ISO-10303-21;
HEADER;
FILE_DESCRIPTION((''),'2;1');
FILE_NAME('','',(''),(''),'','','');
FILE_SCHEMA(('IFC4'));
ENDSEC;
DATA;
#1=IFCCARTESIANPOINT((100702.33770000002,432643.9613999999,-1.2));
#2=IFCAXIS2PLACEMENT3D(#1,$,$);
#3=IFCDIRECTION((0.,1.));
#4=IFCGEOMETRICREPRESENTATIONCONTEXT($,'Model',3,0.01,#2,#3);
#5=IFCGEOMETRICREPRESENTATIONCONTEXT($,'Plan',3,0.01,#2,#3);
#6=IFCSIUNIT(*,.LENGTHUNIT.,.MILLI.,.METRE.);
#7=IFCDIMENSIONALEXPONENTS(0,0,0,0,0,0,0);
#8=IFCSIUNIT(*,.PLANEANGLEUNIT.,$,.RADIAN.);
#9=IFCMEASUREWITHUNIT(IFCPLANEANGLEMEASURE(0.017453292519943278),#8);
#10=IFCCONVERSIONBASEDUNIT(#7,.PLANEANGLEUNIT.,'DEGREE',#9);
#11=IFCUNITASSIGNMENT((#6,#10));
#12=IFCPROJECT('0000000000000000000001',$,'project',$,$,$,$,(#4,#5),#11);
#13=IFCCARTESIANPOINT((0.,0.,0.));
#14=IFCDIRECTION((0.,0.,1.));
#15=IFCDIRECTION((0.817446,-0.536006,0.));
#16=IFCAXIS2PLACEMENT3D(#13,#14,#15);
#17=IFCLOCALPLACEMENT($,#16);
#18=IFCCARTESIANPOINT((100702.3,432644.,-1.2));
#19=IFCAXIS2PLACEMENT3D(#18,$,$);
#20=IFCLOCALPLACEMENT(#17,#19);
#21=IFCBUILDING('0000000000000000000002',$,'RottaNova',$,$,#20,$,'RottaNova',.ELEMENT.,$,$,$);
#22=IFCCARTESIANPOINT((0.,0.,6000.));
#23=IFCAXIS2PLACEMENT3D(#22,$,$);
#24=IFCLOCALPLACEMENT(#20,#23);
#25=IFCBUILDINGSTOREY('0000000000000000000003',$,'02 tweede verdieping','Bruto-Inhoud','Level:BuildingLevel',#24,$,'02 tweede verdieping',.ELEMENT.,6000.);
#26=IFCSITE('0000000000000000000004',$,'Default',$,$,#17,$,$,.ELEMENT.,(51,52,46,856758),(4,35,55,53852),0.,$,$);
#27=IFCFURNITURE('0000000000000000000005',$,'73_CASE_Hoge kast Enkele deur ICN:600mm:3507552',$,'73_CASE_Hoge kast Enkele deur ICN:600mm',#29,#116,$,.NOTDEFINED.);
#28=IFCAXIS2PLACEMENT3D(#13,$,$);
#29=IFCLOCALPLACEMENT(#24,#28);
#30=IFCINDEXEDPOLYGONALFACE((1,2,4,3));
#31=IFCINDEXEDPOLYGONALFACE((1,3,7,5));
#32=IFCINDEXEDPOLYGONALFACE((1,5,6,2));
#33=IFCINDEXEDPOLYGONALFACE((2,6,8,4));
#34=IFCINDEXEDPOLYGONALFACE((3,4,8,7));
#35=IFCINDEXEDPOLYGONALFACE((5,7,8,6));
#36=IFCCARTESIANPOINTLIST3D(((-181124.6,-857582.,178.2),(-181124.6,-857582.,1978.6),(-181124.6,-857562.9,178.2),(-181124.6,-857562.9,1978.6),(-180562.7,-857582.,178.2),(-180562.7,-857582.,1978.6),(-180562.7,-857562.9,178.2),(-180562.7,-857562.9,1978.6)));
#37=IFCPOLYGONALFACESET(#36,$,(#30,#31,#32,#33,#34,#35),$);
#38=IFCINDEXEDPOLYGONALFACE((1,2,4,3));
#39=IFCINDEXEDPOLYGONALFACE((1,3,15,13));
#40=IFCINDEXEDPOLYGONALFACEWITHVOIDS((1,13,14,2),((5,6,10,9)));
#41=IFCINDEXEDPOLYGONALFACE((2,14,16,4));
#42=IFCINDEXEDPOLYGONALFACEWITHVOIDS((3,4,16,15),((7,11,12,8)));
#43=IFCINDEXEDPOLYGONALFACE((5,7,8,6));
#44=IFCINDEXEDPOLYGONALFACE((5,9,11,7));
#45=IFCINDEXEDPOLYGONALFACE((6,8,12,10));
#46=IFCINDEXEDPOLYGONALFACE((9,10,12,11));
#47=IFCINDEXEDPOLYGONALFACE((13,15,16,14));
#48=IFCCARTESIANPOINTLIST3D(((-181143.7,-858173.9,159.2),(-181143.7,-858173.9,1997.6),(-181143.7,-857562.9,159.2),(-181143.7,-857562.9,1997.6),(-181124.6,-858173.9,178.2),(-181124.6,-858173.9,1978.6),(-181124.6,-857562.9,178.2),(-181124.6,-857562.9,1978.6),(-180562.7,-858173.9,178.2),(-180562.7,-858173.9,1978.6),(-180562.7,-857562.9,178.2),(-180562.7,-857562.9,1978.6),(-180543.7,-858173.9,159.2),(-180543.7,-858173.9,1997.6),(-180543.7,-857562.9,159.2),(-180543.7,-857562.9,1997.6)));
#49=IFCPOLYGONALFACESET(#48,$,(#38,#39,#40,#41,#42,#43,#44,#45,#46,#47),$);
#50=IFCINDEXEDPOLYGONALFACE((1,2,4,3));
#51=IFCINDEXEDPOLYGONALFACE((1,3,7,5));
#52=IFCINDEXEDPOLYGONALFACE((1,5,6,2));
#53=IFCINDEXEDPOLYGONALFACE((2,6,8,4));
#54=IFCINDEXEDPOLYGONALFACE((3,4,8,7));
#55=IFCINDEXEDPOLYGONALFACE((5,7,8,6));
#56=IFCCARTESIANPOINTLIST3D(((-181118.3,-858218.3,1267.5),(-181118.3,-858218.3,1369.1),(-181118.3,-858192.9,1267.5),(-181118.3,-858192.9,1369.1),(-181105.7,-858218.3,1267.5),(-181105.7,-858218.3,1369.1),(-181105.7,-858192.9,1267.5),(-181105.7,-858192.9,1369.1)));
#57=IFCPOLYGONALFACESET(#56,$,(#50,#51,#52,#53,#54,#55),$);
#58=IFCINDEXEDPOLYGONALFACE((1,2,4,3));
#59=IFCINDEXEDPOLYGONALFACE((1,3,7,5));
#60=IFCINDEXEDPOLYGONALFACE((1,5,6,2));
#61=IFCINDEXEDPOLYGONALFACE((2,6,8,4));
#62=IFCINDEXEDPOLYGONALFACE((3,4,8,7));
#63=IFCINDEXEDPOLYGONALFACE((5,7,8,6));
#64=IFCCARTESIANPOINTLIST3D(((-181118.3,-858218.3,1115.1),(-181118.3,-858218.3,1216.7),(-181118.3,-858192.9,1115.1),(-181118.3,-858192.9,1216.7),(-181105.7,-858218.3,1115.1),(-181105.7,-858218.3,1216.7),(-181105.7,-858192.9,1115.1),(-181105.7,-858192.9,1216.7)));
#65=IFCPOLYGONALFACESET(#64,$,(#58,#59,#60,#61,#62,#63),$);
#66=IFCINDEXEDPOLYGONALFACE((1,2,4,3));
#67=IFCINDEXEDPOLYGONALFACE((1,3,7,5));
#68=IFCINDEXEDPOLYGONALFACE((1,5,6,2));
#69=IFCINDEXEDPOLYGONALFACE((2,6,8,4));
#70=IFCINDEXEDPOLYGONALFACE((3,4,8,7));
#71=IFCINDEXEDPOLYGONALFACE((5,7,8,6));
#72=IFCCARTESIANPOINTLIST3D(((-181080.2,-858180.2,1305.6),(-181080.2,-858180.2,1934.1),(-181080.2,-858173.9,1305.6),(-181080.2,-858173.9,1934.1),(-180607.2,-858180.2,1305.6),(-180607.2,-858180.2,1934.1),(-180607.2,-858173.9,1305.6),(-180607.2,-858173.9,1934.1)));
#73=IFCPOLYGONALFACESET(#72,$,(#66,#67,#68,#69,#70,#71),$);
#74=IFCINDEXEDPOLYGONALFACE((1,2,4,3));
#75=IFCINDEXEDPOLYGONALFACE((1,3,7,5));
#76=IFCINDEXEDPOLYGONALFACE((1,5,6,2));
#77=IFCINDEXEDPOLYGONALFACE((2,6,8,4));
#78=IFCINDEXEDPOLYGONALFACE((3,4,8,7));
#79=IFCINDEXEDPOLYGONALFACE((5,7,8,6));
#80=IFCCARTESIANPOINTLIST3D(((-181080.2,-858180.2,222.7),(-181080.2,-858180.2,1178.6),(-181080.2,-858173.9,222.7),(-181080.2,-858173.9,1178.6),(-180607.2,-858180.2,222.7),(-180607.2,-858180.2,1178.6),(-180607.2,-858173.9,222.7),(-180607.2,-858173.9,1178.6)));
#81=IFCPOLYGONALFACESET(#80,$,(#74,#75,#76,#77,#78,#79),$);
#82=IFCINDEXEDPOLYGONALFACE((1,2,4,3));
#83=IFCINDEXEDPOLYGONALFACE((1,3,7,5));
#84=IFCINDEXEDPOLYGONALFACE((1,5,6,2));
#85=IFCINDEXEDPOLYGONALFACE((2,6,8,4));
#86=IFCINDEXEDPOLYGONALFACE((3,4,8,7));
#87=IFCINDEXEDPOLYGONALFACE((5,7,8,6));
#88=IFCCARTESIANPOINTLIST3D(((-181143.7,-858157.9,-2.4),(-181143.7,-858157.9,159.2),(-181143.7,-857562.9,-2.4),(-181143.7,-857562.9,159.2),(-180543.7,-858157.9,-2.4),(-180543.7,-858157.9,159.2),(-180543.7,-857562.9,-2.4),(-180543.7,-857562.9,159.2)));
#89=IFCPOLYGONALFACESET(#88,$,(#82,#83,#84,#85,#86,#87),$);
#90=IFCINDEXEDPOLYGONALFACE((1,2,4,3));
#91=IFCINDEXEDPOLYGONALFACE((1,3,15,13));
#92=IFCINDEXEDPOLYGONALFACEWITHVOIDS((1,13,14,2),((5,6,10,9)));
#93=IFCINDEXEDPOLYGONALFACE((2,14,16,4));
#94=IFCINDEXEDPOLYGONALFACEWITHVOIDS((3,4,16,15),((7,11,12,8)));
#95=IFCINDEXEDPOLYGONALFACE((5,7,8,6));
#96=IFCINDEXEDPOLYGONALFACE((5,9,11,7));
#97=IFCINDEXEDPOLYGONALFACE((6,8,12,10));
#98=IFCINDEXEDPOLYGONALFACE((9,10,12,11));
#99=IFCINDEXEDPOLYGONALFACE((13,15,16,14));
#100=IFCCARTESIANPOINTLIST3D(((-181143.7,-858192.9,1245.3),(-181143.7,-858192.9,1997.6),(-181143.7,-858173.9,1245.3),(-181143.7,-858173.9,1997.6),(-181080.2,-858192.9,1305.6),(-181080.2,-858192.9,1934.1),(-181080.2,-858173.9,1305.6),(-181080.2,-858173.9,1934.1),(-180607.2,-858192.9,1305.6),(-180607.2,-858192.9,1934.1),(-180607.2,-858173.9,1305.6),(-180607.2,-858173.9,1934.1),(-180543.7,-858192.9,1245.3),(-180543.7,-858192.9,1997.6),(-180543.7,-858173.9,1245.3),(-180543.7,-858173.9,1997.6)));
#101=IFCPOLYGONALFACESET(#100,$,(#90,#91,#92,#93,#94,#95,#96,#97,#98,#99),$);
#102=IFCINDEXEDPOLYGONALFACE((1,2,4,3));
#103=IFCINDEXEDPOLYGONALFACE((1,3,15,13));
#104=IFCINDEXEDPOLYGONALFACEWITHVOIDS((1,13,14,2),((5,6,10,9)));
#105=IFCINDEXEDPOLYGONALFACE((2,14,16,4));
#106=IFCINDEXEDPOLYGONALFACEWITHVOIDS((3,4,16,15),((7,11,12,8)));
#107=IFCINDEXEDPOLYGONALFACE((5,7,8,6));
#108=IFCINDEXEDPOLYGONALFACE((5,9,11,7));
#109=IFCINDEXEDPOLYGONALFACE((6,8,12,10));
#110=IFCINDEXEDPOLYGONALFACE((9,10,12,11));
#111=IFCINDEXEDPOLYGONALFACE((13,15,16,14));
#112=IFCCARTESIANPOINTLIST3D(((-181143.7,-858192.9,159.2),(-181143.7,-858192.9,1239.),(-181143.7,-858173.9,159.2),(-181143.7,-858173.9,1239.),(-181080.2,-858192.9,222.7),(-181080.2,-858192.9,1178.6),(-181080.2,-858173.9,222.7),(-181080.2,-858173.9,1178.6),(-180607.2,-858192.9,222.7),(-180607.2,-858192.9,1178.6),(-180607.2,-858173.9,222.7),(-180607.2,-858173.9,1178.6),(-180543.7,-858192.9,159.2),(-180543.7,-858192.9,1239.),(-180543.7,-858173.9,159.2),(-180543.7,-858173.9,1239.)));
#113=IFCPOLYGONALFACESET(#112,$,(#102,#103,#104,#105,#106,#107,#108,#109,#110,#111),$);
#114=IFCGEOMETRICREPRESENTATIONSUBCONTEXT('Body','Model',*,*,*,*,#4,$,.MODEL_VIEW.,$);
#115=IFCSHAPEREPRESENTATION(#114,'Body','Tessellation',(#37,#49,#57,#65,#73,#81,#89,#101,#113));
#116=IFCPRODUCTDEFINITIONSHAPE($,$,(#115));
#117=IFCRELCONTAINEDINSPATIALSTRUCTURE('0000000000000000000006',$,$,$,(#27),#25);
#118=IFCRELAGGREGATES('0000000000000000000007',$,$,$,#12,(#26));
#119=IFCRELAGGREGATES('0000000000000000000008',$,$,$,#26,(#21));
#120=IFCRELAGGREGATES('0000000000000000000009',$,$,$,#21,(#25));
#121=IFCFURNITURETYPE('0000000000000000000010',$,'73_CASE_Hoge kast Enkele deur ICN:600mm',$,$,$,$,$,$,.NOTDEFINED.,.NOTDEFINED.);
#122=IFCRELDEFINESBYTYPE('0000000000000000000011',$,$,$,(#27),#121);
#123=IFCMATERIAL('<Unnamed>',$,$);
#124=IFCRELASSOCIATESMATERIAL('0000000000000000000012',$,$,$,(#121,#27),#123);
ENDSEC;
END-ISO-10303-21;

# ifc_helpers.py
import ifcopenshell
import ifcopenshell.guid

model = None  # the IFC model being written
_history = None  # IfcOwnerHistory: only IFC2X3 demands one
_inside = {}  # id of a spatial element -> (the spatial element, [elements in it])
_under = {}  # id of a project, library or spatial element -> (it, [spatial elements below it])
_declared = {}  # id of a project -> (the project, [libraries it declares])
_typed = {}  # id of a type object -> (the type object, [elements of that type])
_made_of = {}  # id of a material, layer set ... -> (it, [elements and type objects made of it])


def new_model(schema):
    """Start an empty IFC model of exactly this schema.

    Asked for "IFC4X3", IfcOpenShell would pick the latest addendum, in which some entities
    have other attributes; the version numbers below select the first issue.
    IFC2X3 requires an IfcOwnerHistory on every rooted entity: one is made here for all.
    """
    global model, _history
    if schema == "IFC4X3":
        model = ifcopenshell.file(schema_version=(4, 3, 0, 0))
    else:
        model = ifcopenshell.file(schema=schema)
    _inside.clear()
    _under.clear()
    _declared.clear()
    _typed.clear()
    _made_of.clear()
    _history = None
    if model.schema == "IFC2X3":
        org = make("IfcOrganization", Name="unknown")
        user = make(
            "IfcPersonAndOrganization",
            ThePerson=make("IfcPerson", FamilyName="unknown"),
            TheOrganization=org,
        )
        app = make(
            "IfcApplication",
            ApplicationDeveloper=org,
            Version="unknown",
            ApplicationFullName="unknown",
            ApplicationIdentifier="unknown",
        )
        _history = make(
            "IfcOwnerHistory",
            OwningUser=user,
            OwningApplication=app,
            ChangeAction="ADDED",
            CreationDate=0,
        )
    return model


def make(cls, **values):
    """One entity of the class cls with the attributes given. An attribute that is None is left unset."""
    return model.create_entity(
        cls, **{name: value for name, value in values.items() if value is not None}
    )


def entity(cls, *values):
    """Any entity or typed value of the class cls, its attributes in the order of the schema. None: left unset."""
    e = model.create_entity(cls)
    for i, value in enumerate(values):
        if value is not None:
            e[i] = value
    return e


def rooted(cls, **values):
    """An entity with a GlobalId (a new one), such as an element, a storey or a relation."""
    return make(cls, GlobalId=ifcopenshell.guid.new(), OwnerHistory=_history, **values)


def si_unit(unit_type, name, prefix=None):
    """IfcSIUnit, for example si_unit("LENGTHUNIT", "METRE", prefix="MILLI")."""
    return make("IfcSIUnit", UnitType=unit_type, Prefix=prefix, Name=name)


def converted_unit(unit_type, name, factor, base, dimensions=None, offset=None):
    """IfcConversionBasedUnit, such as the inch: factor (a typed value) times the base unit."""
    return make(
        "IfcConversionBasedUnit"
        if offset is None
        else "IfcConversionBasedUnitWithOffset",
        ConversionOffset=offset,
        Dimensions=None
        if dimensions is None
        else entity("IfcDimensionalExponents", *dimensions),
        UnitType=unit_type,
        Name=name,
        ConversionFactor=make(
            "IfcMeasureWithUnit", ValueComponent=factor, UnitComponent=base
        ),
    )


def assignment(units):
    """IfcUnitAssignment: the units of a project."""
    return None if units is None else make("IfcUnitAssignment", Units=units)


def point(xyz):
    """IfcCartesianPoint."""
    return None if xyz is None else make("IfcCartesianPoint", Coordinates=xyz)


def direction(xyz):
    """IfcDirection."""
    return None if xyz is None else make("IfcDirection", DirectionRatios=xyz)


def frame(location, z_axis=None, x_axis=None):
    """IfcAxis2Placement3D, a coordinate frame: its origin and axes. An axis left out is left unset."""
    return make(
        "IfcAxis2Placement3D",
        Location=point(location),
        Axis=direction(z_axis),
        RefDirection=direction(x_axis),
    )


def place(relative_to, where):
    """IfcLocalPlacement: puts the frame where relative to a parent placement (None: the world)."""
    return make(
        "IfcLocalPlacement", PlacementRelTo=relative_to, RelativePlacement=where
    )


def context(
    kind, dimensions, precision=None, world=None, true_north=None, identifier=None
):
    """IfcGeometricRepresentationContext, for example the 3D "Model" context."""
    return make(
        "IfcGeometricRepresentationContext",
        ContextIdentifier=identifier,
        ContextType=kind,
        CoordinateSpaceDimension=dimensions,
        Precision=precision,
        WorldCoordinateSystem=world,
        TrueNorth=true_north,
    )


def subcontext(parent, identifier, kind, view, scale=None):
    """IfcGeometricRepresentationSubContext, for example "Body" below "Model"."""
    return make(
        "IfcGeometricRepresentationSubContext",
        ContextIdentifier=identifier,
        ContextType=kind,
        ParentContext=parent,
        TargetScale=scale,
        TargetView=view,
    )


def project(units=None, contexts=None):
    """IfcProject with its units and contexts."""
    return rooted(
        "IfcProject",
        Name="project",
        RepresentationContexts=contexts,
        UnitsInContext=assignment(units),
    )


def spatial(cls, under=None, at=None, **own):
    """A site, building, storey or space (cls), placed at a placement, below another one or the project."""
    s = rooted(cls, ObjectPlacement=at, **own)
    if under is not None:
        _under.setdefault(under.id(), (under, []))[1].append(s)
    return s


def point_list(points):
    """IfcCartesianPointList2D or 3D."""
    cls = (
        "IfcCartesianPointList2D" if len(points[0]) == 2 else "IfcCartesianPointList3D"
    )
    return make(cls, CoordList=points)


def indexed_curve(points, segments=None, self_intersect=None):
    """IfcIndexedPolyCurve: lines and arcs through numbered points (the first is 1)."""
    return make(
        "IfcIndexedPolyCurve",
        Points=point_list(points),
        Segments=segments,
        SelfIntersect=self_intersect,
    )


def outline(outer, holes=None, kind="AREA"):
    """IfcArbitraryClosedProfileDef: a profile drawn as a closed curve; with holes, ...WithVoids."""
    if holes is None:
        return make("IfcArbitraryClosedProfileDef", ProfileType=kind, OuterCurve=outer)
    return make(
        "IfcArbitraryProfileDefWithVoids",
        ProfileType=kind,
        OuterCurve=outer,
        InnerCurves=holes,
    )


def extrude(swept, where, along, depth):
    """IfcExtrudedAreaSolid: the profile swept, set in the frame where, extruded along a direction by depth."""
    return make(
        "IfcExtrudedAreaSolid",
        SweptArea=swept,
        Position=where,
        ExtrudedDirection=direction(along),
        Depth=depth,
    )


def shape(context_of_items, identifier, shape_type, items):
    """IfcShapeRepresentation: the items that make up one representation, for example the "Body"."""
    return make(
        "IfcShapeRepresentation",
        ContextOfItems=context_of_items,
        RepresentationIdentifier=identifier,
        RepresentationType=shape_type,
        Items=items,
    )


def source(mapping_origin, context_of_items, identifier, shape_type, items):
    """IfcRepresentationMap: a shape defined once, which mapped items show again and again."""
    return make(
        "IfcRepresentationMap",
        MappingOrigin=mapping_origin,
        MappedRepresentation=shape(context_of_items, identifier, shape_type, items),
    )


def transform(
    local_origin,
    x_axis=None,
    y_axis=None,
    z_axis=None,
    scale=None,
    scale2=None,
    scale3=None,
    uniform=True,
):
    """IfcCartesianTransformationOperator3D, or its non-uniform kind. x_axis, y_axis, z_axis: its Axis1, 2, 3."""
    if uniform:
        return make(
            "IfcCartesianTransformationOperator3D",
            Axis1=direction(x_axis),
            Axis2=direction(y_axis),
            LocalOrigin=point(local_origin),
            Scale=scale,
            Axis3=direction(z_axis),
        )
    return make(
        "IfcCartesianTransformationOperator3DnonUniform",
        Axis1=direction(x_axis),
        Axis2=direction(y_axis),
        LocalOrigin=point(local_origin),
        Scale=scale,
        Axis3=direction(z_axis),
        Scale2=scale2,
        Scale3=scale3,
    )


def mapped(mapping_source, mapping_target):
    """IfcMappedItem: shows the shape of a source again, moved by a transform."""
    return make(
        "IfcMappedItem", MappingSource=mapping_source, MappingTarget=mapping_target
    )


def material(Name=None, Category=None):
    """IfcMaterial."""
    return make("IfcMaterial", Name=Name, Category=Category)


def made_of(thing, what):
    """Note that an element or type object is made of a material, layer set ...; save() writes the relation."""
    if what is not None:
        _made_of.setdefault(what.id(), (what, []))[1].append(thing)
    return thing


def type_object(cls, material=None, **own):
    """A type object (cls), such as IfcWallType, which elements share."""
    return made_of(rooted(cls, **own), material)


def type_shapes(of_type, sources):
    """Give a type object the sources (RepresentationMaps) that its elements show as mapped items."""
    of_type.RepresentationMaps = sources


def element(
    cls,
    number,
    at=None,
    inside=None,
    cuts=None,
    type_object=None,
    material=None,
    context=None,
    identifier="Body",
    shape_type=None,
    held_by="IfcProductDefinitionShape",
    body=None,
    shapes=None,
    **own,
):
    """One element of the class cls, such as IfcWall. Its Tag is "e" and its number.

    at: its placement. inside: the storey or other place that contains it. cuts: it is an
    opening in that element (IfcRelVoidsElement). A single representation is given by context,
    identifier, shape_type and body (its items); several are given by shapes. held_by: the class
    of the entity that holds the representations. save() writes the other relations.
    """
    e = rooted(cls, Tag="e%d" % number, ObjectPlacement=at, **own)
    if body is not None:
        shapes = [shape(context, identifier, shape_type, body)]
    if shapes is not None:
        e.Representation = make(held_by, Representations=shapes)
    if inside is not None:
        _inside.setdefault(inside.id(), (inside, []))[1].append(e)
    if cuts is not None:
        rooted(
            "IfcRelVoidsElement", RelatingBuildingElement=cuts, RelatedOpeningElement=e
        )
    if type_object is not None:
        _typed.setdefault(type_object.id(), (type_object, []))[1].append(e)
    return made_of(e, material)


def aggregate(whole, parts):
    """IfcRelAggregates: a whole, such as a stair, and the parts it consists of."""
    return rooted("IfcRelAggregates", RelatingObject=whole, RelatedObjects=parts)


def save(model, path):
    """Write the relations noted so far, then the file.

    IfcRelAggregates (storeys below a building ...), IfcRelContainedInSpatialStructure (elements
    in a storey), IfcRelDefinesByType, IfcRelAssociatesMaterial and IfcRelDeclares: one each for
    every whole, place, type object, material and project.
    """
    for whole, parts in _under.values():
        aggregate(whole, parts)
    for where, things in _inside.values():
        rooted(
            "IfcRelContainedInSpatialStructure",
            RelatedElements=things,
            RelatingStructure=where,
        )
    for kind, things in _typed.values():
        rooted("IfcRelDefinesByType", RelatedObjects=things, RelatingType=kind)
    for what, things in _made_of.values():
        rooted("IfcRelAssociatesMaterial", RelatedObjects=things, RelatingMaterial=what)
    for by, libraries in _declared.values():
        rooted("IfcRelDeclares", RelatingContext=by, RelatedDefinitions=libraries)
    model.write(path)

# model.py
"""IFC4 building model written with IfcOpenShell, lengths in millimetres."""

from ifc_helpers import new_model, entity, si_unit, converted_unit, direction, frame, place, context, subcontext, project, spatial, indexed_curve, outline, extrude, source, transform, mapped, material, type_object, type_shapes, element, save


model = new_model("IFC4")

# Units and contexts
model_context = context("Model", 3, precision=0.01, world=frame((100702.33770000002, 432643.9613999999, -1.2)), true_north=direction((0.0, 1.0)))
plan_context = context("Plan", 3, precision=0.01, world=frame((100702.33770000002, 432643.9613999999, -1.2)), true_north=direction((0.0, 1.0)))
body_context = subcontext(model_context, "Body", "Model", "MODEL_VIEW")
ifc_project = project(units=[si_unit("LENGTHUNIT", "METRE", prefix="MILLI"), converted_unit("PLANEANGLEUNIT", "DEGREE", entity("IfcPlaneAngleMeasure", 0.017453292519943278), si_unit("PLANEANGLEUNIT", "RADIAN"), dimensions=[0, 0, 0, 0, 0, 0, 0])], contexts=[model_context, plan_context])

# Site, building, storey
site_placement = place(None, frame((0.0, 0.0, 0.0), z_axis=(0.0, 0.0, 1.0), x_axis=(0.817446, -0.536006, 0.0)))
site = spatial("IfcSite", under=ifc_project, at=site_placement, Name="Default", CompositionType="ELEMENT", RefLatitude=(51, 52, 46, 856758), RefLongitude=(4, 35, 55, 53852), RefElevation=0.0)
building_placement = place(site_placement, frame((100702.3, 432644.0, -1.2)))
building = spatial("IfcBuilding", under=site, at=building_placement, Name="RottaNova", LongName="RottaNova", CompositionType="ELEMENT")
storey_placement = place(building_placement, frame((0.0, 0.0, 6000.0)))
storey = spatial("IfcBuildingStorey", under=building, at=storey_placement, Name="02 tweede verdieping", Description="Bruto-Inhoud", ObjectType="Level:BuildingLevel", LongName="02 tweede verdieping", CompositionType="ELEMENT", Elevation=6000.0)

# Furniture
ifc_material_1 = material(Name="<Unnamed>")
furniture_type = type_object("IfcFurnitureType", Name="73_CASE_Hoge kast Enkele deur ICN:600mm", AssemblyPlace="NOTDEFINED", PredefinedType="NOTDEFINED", material=ifc_material_1)
shared_shape_1 = source(frame((100702.3, 432644.0, -1.2)), body_context, "Body", "SweptSolid", [
    extrude(outline(indexed_curve([(-280.9, -9.5), (280.9, -9.5), (280.9, 9.5), (-280.9, 9.5), (-280.9, -9.5)], self_intersect=False)), frame((18.7, 9.5, 180.6), z_axis=(0.0, 0.0, 1.0), x_axis=(-1.0, 0.0, 0.0)), (0.0, 0.0, 1.0), 1800.3),
    extrude(outline(indexed_curve([(-300.0, -919.2), (300.0, -919.2), (300.0, 919.2), (-300.0, 919.2), (-300.0, -919.2)], self_intersect=False), holes=[indexed_curve([(-280.9, 900.2), (281.0, 900.2), (281.0, -900.2), (-280.9, -900.2), (-280.9, 900.2)], self_intersect=False)]), frame((18.7, 0.0, 1080.8), z_axis=(0.0, 1.0, 0.0), x_axis=(-1.0, 0.0, 0.0)), (0.0, 0.0, 1.0), 610.9),
    extrude(outline(indexed_curve([(-6.3, -12.7), (6.3, -12.7), (6.3, 12.7), (-6.3, 12.7), (-6.3, -12.7)], self_intersect=False)), frame((287.1, 642.7, 1269.9), z_axis=(0.0, 0.0, 1.0), x_axis=(-1.0, 0.0, 0.0)), (0.0, 0.0, 1.0), 101.6),
    extrude(outline(indexed_curve([(-6.3, -12.7), (6.3, -12.7), (6.3, 12.7), (-6.3, 12.7), (-6.3, -12.7)], self_intersect=False)), frame((287.1, 642.7, 1117.5), z_axis=(0.0, 0.0, 1.0), x_axis=(-1.0, 0.0, 0.0)), (0.0, 0.0, 1.0), 101.6),
    extrude(outline(indexed_curve([(-236.5, -3.2), (236.5, -3.2), (236.5, 3.2), (-236.5, 3.2), (-236.5, -3.2)], self_intersect=False)), frame((18.7, 614.1, 1308.0), z_axis=(0.0, 0.0, 1.0), x_axis=(-1.0, 0.0, 0.0)), (0.0, 0.0, 1.0), 628.5),
    extrude(outline(indexed_curve([(-236.5, -3.2), (236.5, -3.2), (236.5, 3.2), (-236.5, 3.2), (-236.5, -3.2)], self_intersect=False)), frame((18.7, 614.1, 225.1), z_axis=(0.0, 0.0, 1.0), x_axis=(-1.0, 0.0, 0.0)), (0.0, 0.0, 1.0), 956.0),
    extrude(outline(indexed_curve([(-297.5, -300.0), (297.5, -300.0), (297.5, 300.0), (-297.5, 300.0), (-297.5, -300.0)], self_intersect=False)), frame((18.7, 297.5, 0.0), z_axis=(0.0, 0.0, 1.0), x_axis=(0.0, 1.0, 0.0)), (0.0, 0.0, 1.0), 161.6),
    extrude(outline(indexed_curve([(-376.1, -300.0), (376.1, -300.0), (376.1, 300.0), (-376.1, 300.0), (-376.1, -300.0)], self_intersect=False), holes=[indexed_curve([(-312.6, -236.5), (-312.6, 236.5), (315.8, 236.5), (315.8, -236.5), (-312.6, -236.5)], self_intersect=False)]), frame((18.7, 610.9, 1623.9), z_axis=(0.0, 1.0, 0.0), x_axis=(0.0, 0.0, -1.0)), (0.0, 0.0, 1.0), 19.1),
    extrude(outline(indexed_curve([(-300.0, -539.9), (300.0, -539.9), (300.0, 539.9), (-300.0, 539.9), (-300.0, -539.9)], self_intersect=False), holes=[indexed_curve([(-236.5, 479.6), (236.5, 479.6), (236.5, -476.4), (-236.5, -476.4), (-236.5, 479.6)], self_intersect=False)]), frame((18.7, 610.9, 701.5), z_axis=(0.0, 1.0, 0.0), x_axis=(-1.0, 0.0, 0.0)), (0.0, 0.0, 1.0), 19.1),
])
type_shapes(furniture_type, [shared_shape_1])
for number, where, z_axis, x_axis, name in (
    (1, (20579.7, 7725.0, 0.0), (0.0, 0.0, 1.0), (-1.0, 0.0, 0.0), "73_CASE_Hoge kast Enkele deur ICN:600mm:3507552"),
):
    element("IfcFurniture", number, at=place(storey_placement, frame(where, z_axis=z_axis, x_axis=x_axis)), inside=storey, type_object=furniture_type, material=ifc_material_1, Name=name, ObjectType="73_CASE_Hoge kast Enkele deur ICN:600mm", PredefinedType="NOTDEFINED", context=body_context, shape_type="MappedRepresentation", body=[
        mapped(shared_shape_1, transform((100702.3, 432644.0, -1.2), scale=1.0)),
    ])

save(model, "model.ifc")
